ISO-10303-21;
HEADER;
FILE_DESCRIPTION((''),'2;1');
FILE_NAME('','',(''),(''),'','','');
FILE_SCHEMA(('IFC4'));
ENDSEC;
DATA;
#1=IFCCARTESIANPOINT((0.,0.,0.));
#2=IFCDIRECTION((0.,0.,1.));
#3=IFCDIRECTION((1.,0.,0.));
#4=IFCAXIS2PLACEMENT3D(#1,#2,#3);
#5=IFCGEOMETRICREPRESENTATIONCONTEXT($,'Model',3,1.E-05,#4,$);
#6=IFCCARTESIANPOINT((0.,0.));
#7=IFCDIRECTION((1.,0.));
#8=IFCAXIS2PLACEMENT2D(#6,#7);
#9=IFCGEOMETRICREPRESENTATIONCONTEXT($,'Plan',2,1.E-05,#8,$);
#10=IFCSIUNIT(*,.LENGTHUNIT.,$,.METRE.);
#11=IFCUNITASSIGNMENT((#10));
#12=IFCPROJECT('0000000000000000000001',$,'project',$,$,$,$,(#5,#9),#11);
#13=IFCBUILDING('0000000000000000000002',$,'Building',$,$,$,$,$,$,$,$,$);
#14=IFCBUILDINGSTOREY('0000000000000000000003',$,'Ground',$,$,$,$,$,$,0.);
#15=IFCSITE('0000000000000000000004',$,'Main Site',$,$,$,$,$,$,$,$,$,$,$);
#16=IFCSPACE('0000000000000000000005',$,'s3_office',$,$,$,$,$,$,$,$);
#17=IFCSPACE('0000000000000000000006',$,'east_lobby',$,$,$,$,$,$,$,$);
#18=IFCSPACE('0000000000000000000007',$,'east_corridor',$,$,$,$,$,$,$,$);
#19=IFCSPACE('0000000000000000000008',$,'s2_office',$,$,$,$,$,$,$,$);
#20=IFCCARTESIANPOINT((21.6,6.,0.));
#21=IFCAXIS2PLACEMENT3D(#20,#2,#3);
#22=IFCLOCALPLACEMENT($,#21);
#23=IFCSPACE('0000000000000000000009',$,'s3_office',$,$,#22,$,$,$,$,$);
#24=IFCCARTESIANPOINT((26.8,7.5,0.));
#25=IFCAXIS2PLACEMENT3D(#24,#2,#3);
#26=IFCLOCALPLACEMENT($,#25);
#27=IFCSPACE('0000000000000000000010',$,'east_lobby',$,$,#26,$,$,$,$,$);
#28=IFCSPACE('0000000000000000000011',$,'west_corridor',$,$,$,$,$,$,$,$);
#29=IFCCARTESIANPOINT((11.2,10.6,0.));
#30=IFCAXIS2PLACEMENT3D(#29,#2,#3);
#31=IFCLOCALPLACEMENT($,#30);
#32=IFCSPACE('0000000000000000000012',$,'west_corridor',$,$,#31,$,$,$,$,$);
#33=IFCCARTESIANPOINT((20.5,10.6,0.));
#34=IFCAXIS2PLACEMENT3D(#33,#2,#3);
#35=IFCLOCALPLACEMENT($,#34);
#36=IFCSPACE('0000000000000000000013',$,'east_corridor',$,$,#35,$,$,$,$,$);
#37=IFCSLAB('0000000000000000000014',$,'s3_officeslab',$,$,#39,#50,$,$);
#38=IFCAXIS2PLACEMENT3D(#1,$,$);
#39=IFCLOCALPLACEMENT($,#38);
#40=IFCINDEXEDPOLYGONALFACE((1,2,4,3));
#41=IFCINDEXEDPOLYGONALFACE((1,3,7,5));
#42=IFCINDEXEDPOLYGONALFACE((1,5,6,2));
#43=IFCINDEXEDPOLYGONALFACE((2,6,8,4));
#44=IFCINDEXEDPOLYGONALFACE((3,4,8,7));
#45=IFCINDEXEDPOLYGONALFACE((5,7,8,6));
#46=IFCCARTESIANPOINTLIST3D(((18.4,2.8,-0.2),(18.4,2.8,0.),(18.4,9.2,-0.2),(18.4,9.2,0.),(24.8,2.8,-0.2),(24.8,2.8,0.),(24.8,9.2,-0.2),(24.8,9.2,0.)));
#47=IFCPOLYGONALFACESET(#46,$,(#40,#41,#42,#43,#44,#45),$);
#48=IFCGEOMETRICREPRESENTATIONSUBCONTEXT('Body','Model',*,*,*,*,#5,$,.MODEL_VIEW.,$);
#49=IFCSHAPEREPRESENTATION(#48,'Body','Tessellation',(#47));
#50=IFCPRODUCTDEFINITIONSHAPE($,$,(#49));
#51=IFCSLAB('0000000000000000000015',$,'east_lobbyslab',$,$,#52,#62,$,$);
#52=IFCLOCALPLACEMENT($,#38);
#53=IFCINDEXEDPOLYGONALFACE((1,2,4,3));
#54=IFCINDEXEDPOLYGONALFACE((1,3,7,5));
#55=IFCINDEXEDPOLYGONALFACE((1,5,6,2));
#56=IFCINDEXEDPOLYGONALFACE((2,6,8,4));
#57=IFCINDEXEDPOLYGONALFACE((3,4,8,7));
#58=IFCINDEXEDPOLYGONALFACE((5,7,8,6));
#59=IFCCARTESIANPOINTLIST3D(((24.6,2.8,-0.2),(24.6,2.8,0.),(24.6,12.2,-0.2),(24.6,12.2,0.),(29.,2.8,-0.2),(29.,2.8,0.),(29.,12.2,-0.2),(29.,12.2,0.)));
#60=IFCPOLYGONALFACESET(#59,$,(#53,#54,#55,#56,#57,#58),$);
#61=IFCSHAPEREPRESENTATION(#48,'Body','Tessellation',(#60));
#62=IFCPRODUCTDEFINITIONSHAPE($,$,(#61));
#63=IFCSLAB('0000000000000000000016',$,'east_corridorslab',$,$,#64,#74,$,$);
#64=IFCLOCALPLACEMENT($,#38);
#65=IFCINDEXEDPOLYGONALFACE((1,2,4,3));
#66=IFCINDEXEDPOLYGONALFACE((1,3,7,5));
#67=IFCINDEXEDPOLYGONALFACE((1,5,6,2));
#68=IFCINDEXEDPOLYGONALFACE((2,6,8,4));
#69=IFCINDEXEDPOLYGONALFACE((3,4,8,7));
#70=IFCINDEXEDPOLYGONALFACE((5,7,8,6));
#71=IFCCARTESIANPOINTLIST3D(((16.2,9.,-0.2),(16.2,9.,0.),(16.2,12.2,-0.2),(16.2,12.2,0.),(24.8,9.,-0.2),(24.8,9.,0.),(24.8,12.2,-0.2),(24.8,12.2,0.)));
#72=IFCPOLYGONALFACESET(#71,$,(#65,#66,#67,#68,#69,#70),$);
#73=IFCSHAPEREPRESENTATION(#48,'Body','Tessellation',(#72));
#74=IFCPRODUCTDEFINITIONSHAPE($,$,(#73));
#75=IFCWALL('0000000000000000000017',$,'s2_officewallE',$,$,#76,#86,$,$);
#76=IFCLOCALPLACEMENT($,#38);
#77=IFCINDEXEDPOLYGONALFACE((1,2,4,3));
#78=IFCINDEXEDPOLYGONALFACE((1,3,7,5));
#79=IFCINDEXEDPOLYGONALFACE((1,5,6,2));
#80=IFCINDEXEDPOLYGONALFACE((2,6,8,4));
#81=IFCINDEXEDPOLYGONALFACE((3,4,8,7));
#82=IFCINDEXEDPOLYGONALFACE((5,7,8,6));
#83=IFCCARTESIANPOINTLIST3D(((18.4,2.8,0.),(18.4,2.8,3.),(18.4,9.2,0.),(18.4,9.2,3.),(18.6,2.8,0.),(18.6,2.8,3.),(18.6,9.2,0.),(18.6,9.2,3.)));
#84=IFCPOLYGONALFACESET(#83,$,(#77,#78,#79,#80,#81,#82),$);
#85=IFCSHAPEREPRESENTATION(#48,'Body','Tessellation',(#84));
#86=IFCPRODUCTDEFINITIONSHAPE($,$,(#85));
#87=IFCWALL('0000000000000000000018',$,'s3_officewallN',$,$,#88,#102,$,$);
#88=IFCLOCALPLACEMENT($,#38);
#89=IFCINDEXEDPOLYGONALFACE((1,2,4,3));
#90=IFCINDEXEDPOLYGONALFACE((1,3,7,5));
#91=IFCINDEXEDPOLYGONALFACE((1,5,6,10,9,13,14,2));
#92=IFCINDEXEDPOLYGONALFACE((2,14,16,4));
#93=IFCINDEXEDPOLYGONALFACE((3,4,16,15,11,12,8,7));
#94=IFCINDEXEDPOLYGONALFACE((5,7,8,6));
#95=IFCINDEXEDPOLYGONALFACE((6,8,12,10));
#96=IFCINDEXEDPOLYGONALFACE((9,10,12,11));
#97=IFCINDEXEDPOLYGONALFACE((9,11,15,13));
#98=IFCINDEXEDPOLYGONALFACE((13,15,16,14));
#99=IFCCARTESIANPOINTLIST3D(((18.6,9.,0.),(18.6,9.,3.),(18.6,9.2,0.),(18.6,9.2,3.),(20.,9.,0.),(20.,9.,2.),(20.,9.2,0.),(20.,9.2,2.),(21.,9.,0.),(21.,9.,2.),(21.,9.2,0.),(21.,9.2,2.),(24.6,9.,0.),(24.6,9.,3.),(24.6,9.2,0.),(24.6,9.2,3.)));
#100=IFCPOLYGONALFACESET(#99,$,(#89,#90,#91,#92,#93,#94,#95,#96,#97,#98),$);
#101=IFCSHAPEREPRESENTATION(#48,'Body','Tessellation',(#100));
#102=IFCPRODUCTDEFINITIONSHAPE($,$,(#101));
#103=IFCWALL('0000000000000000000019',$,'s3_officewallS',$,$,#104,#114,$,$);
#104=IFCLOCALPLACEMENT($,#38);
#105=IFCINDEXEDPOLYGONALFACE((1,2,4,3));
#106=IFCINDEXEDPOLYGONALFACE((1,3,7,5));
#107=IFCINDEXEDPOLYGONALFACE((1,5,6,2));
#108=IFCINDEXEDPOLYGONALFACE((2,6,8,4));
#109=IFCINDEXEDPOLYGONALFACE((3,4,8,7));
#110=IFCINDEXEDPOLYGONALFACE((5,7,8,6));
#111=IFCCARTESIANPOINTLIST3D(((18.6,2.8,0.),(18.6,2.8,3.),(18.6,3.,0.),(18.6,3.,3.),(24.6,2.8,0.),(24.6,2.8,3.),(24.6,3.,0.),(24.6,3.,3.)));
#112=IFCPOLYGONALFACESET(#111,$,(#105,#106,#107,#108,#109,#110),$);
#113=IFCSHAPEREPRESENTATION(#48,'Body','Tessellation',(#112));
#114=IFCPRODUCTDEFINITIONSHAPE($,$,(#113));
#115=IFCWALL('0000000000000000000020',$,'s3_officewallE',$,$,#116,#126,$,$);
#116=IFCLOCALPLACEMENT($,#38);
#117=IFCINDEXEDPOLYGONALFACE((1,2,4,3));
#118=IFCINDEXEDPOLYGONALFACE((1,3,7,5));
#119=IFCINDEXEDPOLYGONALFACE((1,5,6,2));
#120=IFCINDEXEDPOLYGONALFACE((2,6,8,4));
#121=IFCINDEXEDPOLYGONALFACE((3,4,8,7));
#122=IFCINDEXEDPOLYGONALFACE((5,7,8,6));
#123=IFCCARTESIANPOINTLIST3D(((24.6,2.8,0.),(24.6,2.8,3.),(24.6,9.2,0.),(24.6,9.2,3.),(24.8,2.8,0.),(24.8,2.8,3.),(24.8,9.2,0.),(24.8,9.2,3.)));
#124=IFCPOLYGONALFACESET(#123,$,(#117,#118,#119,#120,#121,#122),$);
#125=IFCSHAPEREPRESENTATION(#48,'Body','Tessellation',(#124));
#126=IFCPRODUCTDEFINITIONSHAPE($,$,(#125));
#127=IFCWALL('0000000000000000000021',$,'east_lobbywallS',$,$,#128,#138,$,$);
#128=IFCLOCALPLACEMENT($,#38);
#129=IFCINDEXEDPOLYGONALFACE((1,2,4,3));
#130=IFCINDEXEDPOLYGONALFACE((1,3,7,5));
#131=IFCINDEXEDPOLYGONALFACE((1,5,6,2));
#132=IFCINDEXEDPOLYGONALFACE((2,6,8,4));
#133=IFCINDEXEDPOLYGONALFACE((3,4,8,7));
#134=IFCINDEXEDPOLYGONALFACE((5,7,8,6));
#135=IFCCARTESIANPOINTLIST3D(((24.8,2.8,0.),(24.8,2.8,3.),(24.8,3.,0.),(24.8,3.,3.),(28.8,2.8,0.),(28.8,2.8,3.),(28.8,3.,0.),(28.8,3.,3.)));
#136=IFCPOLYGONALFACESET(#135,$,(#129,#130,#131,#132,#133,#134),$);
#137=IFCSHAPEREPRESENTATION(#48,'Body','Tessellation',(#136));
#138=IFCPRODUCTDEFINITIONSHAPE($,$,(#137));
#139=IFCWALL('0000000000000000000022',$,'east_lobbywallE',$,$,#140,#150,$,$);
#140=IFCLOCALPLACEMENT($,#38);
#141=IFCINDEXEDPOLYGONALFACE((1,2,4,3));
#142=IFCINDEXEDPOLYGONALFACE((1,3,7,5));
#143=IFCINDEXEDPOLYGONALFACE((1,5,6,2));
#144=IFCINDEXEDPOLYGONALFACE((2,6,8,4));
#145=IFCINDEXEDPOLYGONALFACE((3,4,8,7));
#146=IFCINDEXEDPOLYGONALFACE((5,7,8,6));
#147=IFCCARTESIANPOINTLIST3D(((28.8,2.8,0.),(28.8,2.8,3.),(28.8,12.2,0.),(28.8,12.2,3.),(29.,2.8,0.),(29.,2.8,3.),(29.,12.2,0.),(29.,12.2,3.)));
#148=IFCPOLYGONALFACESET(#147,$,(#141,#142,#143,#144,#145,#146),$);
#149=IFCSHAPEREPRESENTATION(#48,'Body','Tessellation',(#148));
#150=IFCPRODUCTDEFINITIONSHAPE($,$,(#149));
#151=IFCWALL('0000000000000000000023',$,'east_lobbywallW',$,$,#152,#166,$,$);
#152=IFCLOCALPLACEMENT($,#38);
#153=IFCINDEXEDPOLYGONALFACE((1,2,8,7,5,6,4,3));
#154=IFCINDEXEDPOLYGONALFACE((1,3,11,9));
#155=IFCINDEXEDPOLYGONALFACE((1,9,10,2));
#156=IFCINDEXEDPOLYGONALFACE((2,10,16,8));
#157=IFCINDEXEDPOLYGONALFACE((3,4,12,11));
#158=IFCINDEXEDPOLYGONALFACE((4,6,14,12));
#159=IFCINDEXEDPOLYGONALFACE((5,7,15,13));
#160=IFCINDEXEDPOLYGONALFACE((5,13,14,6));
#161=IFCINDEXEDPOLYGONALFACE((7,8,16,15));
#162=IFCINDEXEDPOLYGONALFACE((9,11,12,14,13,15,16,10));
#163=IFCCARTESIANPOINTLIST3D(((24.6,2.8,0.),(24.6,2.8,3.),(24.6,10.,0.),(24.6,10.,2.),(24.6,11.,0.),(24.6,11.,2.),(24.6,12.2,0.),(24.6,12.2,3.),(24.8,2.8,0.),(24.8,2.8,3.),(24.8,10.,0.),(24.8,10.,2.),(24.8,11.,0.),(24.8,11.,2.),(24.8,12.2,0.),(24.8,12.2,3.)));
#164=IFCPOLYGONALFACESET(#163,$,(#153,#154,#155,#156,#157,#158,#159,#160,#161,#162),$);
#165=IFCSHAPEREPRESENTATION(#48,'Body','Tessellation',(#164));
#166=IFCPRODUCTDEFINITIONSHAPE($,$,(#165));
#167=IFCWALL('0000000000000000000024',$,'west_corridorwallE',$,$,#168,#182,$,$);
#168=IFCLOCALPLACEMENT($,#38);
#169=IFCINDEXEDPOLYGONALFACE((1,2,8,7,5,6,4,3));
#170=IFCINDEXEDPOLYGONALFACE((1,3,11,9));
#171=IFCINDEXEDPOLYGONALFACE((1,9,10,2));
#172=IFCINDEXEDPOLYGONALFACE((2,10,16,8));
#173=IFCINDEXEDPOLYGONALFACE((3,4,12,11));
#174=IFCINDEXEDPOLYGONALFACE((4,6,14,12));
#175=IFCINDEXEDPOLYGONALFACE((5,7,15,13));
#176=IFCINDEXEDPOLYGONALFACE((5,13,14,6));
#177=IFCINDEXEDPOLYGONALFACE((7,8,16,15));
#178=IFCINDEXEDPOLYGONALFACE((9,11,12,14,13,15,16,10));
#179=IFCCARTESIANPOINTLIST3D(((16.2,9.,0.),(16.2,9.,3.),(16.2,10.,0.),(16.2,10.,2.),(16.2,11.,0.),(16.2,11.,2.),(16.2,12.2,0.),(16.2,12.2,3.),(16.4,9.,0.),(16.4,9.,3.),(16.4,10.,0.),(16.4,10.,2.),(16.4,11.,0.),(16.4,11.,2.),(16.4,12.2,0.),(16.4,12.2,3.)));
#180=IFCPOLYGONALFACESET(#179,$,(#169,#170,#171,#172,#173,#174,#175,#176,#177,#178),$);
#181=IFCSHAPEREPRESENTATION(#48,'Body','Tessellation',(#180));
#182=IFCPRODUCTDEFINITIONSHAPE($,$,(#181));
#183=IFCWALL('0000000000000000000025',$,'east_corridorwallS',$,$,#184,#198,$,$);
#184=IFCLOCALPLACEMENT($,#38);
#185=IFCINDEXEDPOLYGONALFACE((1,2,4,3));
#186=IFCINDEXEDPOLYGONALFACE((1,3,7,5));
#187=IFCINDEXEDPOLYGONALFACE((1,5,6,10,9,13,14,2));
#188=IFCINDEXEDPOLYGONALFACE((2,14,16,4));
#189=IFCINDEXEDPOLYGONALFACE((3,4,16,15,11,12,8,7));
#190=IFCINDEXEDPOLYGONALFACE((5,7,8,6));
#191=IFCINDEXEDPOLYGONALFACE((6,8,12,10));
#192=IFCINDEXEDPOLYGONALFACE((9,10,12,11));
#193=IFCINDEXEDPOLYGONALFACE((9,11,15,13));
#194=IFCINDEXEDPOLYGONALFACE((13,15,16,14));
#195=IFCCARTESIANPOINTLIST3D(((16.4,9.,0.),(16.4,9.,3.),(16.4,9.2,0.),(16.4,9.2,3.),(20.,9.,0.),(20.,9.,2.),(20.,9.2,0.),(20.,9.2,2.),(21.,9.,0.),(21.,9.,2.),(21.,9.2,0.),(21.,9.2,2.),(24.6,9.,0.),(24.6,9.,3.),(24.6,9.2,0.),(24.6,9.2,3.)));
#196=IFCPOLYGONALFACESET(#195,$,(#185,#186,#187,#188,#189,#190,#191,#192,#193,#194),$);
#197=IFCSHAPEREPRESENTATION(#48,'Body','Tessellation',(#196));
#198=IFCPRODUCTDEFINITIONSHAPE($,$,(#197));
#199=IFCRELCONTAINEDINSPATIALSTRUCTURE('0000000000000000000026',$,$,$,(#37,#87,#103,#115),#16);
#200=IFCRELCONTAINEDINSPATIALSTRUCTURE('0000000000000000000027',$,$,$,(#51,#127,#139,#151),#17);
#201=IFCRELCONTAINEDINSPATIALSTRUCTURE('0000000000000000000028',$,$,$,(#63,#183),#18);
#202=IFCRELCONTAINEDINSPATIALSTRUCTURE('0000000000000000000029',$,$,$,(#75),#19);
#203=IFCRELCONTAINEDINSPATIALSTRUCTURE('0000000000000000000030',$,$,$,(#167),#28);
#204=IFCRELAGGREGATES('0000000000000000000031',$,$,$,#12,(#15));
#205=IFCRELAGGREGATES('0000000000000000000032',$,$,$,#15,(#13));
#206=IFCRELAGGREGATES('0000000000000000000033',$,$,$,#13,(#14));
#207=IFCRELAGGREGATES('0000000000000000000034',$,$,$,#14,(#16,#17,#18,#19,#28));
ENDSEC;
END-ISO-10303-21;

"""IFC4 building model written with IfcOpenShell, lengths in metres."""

from ifc_helpers import new_model, si_unit, frame, origin_with_axes, origin_2d_with_axis, place, context, subcontext, project, spatial, indexed_curve, rectangle, outline, extrude, element, save


model = new_model("IFC4")

# Units and contexts
model_context = context("Model", 3, precision=1e-05, world=origin_with_axes())
plan_context = context("Plan", 2, precision=1e-05, world=origin_2d_with_axis())
body_context = subcontext(model_context, "Body", "Model", "MODEL_VIEW")
ifc_project = project(units=[si_unit("LENGTHUNIT", "METRE")], contexts=[model_context, plan_context])

# Site, building, storey, space
site = spatial("IfcSite", under=ifc_project, Name="Main Site")
building = spatial("IfcBuilding", under=site, Name="Building")
storey = spatial("IfcBuildingStorey", under=building, Name="Ground", Elevation=0.0)
space_1 = spatial("IfcSpace", under=storey, Name="s3_office")

# Slab
slab_1_placement = place(None, frame((21.6, 6.0, -0.2), z_axis=(0.0, 0.0, 1.0), x_axis=(1.0, 0.0, 0.0)))
element("IfcSlab", 1, at=slab_1_placement, inside=space_1, Name="s3_officeslab", context=body_context, shape_type="SweptSolid", body=[
    extrude(rectangle(XDim=6.4, YDim=6.4), origin_with_axes(), (0.0, 0.0, 1.0), 0.2),
])

# Shared definitions
space_2 = spatial("IfcSpace", under=storey, Name="east_lobby")

# Slab
slab_2_placement = place(None, frame((26.8, 7.5, -0.2), z_axis=(0.0, 0.0, 1.0), x_axis=(1.0, 0.0, 0.0)))
element("IfcSlab", 2, at=slab_2_placement, inside=space_2, Name="east_lobbyslab", context=body_context, shape_type="SweptSolid", body=[
    extrude(rectangle(XDim=4.4, YDim=9.4), origin_with_axes(), (0.0, 0.0, 1.0), 0.2),
])

# Shared definitions
space_3 = spatial("IfcSpace", under=storey, Name="east_corridor")

# Slab
slab_3_placement = place(None, frame((20.5, 10.6, -0.2), z_axis=(0.0, 0.0, 1.0), x_axis=(1.0, 0.0, 0.0)))
element("IfcSlab", 3, at=slab_3_placement, inside=space_3, Name="east_corridorslab", context=body_context, shape_type="SweptSolid", body=[
    extrude(rectangle(XDim=8.6, YDim=3.2), origin_with_axes(), (0.0, 0.0, 1.0), 0.2),
])

# Shared definitions
space_4 = spatial("IfcSpace", under=storey, Name="s2_office")

# Walls
wall_1_placement = place(None, frame((18.6, 2.8, 0.0), z_axis=(0.0, 0.0, 1.0), x_axis=(0.0, 1.0, 0.0)))
element("IfcWall", 4, at=wall_1_placement, inside=space_4, Name="s2_officewallE", context=body_context, shape_type="SweptSolid", body=[
    extrude(outline(indexed_curve([(0.0, 0.0), (0.0, 0.2), (6.4, 0.2), (6.4, 0.0), (0.0, 0.0)], self_intersect=False)), origin_with_axes(), (0.0, 0.0, 1.0), 3.0),
])
wall_2_placement = place(None, frame((18.6, 9.0, 0.0), z_axis=(0.0, 0.0, 1.0), x_axis=(1.0, 0.0, 0.0)))
wall_2 = element("IfcWall", 5, at=wall_2_placement, inside=space_1, Name="s3_officewallN", context=body_context, shape_type="SweptSolid", body=[
    extrude(outline(indexed_curve([(0.0, 0.0), (0.0, 0.2), (6.0, 0.2), (6.0, 0.0), (0.0, 0.0)], self_intersect=False)), origin_with_axes(), (0.0, 0.0, 1.0), 3.0),
])

# Shared definitions
space_5_placement = place(None, frame((21.6, 6.0, 0.0), z_axis=(0.0, 0.0, 1.0), x_axis=(1.0, 0.0, 0.0)))
space_5 = spatial("IfcSpace", at=space_5_placement, Name="s3_office")

# Opening
opening_1_placement = place(wall_2_placement, frame((1.4, 0.0, 0.0), z_axis=(0.0, 0.0, 1.0), x_axis=(1.0, 0.0, 0.0)))
element("IfcOpeningElement", 6, at=opening_1_placement, inside=space_5, cuts=wall_2, context=body_context, shape_type="SweptSolid", body=[
    extrude(outline(indexed_curve([(0.0, 0.0), (0.0, 0.4), (1.0, 0.4), (1.0, 0.0), (0.0, 0.0)], self_intersect=False)), origin_with_axes(), (0.0, 0.0, 1.0), 2.0),
])

# Walls
wall_3_placement = place(None, frame((18.6, 2.8, 0.0), z_axis=(0.0, 0.0, 1.0), x_axis=(1.0, 0.0, 0.0)))
element("IfcWall", 7, at=wall_3_placement, inside=space_1, Name="s3_officewallS", context=body_context, shape_type="SweptSolid", body=[
    extrude(outline(indexed_curve([(0.0, 0.0), (0.0, 0.2), (6.0, 0.2), (6.0, 0.0), (0.0, 0.0)], self_intersect=False)), origin_with_axes(), (0.0, 0.0, 1.0), 3.0),
])
for number, where, z_axis, x_axis, name in (
    (8, (24.8, 2.8, 0.0), (0.0, 0.0, 1.0), (0.0, 1.0, 0.0), "s3_officewallE"),
):
    element("IfcWall", number, at=place(None, frame(where, z_axis=z_axis, x_axis=x_axis)), inside=space_1, Name=name, context=body_context, shape_type="SweptSolid", body=[
        extrude(outline(indexed_curve([(0.0, 0.0), (0.0, 0.2), (6.4, 0.2), (6.4, 0.0), (0.0, 0.0)], self_intersect=False)), origin_with_axes(), (0.0, 0.0, 1.0), 3.0),
    ])
wall_4_placement = place(None, frame((24.8, 2.8, 0.0), z_axis=(0.0, 0.0, 1.0), x_axis=(1.0, 0.0, 0.0)))
element("IfcWall", 9, at=wall_4_placement, inside=space_2, Name="east_lobbywallS", context=body_context, shape_type="SweptSolid", body=[
    extrude(outline(indexed_curve([(0.0, 0.0), (0.0, 0.2), (4.0, 0.2), (4.0, 0.0), (0.0, 0.0)], self_intersect=False)), origin_with_axes(), (0.0, 0.0, 1.0), 3.0),
])
wall_5_placement = place(None, frame((29.0, 2.8, 0.0), z_axis=(0.0, 0.0, 1.0), x_axis=(0.0, 1.0, 0.0)))
element("IfcWall", 10, at=wall_5_placement, inside=space_2, Name="east_lobbywallE", context=body_context, shape_type="SweptSolid", body=[
    extrude(outline(indexed_curve([(0.0, 0.0), (0.0, 0.2), (9.4, 0.2), (9.4, 0.0), (0.0, 0.0)], self_intersect=False)), origin_with_axes(), (0.0, 0.0, 1.0), 3.0),
])

# Wall
wall_6_placement = place(None, frame((24.8, 2.8, 0.0), z_axis=(0.0, 0.0, 1.0), x_axis=(0.0, 1.0, 0.0)))
wall_6 = element("IfcWall", 11, at=wall_6_placement, inside=space_2, Name="east_lobbywallW", context=body_context, shape_type="SweptSolid", body=[
    extrude(outline(indexed_curve([(0.0, 0.0), (0.0, 0.2), (9.4, 0.2), (9.4, 0.0), (0.0, 0.0)], self_intersect=False)), origin_with_axes(), (0.0, 0.0, 1.0), 3.0),
])

# Shared definitions
space_6_placement = place(None, frame((26.8, 7.5, 0.0), z_axis=(0.0, 0.0, 1.0), x_axis=(1.0, 0.0, 0.0)))
space_6 = spatial("IfcSpace", at=space_6_placement, Name="east_lobby")

# Opening
opening_2_placement = place(wall_6_placement, frame((7.2, 0.0, 0.0), z_axis=(0.0, 0.0, 1.0), x_axis=(1.0, 0.0, 0.0)))
element("IfcOpeningElement", 12, at=opening_2_placement, inside=space_6, cuts=wall_6, context=body_context, shape_type="SweptSolid", body=[
    extrude(outline(indexed_curve([(0.0, 0.0), (0.0, 0.4), (1.0, 0.4), (1.0, 0.0), (0.0, 0.0)], self_intersect=False)), origin_with_axes(), (0.0, 0.0, 1.0), 2.0),
])

# Shared definitions
space_7 = spatial("IfcSpace", under=storey, Name="west_corridor")

# Wall
wall_7_placement = place(None, frame((16.4, 9.0, 0.0), z_axis=(0.0, 0.0, 1.0), x_axis=(0.0, 1.0, 0.0)))
wall_7 = element("IfcWall", 13, at=wall_7_placement, inside=space_7, Name="west_corridorwallE", context=body_context, shape_type="SweptSolid", body=[
    extrude(outline(indexed_curve([(0.0, 0.0), (0.0, 0.2), (3.2, 0.2), (3.2, 0.0), (0.0, 0.0)], self_intersect=False)), origin_with_axes(), (0.0, 0.0, 1.0), 3.0),
])

# Shared definitions
space_8_placement = place(None, frame((11.2, 10.6, 0.0), z_axis=(0.0, 0.0, 1.0), x_axis=(1.0, 0.0, 0.0)))
space_8 = spatial("IfcSpace", at=space_8_placement, Name="west_corridor")

# Opening
opening_3_placement = place(wall_7_placement, frame((1.0, 0.0, 0.0), z_axis=(0.0, 0.0, 1.0), x_axis=(1.0, 0.0, 0.0)))
element("IfcOpeningElement", 14, at=opening_3_placement, inside=space_8, cuts=wall_7, context=body_context, shape_type="SweptSolid", body=[
    extrude(outline(indexed_curve([(0.0, 0.0), (0.0, 0.4), (1.0, 0.4), (1.0, 0.0), (0.0, 0.0)], self_intersect=False)), origin_with_axes(), (0.0, 0.0, 1.0), 2.0),
])

# Wall
wall_8_placement = place(None, frame((16.4, 9.0, 0.0), z_axis=(0.0, 0.0, 1.0), x_axis=(1.0, 0.0, 0.0)))
wall_8 = element("IfcWall", 15, at=wall_8_placement, inside=space_3, Name="east_corridorwallS", context=body_context, shape_type="SweptSolid", body=[
    extrude(outline(indexed_curve([(0.0, 0.0), (0.0, 0.2), (8.2, 0.2), (8.2, 0.0), (0.0, 0.0)], self_intersect=False)), origin_with_axes(), (0.0, 0.0, 1.0), 3.0),
])

# Shared definitions
space_9_placement = place(None, frame((20.5, 10.6, 0.0), z_axis=(0.0, 0.0, 1.0), x_axis=(1.0, 0.0, 0.0)))
space_9 = spatial("IfcSpace", at=space_9_placement, Name="east_corridor")

# Opening
opening_4_placement = place(wall_8_placement, frame((3.6, 0.0, 0.0), z_axis=(0.0, 0.0, 1.0), x_axis=(1.0, 0.0, 0.0)))
element("IfcOpeningElement", 16, at=opening_4_placement, inside=space_9, cuts=wall_8, context=body_context, shape_type="SweptSolid", body=[
    extrude(outline(indexed_curve([(0.0, 0.0), (0.0, 0.4), (1.0, 0.4), (1.0, 0.0), (0.0, 0.0)], self_intersect=False)), origin_with_axes(), (0.0, 0.0, 1.0), 2.0),
])

save(model, "model.ifc")
